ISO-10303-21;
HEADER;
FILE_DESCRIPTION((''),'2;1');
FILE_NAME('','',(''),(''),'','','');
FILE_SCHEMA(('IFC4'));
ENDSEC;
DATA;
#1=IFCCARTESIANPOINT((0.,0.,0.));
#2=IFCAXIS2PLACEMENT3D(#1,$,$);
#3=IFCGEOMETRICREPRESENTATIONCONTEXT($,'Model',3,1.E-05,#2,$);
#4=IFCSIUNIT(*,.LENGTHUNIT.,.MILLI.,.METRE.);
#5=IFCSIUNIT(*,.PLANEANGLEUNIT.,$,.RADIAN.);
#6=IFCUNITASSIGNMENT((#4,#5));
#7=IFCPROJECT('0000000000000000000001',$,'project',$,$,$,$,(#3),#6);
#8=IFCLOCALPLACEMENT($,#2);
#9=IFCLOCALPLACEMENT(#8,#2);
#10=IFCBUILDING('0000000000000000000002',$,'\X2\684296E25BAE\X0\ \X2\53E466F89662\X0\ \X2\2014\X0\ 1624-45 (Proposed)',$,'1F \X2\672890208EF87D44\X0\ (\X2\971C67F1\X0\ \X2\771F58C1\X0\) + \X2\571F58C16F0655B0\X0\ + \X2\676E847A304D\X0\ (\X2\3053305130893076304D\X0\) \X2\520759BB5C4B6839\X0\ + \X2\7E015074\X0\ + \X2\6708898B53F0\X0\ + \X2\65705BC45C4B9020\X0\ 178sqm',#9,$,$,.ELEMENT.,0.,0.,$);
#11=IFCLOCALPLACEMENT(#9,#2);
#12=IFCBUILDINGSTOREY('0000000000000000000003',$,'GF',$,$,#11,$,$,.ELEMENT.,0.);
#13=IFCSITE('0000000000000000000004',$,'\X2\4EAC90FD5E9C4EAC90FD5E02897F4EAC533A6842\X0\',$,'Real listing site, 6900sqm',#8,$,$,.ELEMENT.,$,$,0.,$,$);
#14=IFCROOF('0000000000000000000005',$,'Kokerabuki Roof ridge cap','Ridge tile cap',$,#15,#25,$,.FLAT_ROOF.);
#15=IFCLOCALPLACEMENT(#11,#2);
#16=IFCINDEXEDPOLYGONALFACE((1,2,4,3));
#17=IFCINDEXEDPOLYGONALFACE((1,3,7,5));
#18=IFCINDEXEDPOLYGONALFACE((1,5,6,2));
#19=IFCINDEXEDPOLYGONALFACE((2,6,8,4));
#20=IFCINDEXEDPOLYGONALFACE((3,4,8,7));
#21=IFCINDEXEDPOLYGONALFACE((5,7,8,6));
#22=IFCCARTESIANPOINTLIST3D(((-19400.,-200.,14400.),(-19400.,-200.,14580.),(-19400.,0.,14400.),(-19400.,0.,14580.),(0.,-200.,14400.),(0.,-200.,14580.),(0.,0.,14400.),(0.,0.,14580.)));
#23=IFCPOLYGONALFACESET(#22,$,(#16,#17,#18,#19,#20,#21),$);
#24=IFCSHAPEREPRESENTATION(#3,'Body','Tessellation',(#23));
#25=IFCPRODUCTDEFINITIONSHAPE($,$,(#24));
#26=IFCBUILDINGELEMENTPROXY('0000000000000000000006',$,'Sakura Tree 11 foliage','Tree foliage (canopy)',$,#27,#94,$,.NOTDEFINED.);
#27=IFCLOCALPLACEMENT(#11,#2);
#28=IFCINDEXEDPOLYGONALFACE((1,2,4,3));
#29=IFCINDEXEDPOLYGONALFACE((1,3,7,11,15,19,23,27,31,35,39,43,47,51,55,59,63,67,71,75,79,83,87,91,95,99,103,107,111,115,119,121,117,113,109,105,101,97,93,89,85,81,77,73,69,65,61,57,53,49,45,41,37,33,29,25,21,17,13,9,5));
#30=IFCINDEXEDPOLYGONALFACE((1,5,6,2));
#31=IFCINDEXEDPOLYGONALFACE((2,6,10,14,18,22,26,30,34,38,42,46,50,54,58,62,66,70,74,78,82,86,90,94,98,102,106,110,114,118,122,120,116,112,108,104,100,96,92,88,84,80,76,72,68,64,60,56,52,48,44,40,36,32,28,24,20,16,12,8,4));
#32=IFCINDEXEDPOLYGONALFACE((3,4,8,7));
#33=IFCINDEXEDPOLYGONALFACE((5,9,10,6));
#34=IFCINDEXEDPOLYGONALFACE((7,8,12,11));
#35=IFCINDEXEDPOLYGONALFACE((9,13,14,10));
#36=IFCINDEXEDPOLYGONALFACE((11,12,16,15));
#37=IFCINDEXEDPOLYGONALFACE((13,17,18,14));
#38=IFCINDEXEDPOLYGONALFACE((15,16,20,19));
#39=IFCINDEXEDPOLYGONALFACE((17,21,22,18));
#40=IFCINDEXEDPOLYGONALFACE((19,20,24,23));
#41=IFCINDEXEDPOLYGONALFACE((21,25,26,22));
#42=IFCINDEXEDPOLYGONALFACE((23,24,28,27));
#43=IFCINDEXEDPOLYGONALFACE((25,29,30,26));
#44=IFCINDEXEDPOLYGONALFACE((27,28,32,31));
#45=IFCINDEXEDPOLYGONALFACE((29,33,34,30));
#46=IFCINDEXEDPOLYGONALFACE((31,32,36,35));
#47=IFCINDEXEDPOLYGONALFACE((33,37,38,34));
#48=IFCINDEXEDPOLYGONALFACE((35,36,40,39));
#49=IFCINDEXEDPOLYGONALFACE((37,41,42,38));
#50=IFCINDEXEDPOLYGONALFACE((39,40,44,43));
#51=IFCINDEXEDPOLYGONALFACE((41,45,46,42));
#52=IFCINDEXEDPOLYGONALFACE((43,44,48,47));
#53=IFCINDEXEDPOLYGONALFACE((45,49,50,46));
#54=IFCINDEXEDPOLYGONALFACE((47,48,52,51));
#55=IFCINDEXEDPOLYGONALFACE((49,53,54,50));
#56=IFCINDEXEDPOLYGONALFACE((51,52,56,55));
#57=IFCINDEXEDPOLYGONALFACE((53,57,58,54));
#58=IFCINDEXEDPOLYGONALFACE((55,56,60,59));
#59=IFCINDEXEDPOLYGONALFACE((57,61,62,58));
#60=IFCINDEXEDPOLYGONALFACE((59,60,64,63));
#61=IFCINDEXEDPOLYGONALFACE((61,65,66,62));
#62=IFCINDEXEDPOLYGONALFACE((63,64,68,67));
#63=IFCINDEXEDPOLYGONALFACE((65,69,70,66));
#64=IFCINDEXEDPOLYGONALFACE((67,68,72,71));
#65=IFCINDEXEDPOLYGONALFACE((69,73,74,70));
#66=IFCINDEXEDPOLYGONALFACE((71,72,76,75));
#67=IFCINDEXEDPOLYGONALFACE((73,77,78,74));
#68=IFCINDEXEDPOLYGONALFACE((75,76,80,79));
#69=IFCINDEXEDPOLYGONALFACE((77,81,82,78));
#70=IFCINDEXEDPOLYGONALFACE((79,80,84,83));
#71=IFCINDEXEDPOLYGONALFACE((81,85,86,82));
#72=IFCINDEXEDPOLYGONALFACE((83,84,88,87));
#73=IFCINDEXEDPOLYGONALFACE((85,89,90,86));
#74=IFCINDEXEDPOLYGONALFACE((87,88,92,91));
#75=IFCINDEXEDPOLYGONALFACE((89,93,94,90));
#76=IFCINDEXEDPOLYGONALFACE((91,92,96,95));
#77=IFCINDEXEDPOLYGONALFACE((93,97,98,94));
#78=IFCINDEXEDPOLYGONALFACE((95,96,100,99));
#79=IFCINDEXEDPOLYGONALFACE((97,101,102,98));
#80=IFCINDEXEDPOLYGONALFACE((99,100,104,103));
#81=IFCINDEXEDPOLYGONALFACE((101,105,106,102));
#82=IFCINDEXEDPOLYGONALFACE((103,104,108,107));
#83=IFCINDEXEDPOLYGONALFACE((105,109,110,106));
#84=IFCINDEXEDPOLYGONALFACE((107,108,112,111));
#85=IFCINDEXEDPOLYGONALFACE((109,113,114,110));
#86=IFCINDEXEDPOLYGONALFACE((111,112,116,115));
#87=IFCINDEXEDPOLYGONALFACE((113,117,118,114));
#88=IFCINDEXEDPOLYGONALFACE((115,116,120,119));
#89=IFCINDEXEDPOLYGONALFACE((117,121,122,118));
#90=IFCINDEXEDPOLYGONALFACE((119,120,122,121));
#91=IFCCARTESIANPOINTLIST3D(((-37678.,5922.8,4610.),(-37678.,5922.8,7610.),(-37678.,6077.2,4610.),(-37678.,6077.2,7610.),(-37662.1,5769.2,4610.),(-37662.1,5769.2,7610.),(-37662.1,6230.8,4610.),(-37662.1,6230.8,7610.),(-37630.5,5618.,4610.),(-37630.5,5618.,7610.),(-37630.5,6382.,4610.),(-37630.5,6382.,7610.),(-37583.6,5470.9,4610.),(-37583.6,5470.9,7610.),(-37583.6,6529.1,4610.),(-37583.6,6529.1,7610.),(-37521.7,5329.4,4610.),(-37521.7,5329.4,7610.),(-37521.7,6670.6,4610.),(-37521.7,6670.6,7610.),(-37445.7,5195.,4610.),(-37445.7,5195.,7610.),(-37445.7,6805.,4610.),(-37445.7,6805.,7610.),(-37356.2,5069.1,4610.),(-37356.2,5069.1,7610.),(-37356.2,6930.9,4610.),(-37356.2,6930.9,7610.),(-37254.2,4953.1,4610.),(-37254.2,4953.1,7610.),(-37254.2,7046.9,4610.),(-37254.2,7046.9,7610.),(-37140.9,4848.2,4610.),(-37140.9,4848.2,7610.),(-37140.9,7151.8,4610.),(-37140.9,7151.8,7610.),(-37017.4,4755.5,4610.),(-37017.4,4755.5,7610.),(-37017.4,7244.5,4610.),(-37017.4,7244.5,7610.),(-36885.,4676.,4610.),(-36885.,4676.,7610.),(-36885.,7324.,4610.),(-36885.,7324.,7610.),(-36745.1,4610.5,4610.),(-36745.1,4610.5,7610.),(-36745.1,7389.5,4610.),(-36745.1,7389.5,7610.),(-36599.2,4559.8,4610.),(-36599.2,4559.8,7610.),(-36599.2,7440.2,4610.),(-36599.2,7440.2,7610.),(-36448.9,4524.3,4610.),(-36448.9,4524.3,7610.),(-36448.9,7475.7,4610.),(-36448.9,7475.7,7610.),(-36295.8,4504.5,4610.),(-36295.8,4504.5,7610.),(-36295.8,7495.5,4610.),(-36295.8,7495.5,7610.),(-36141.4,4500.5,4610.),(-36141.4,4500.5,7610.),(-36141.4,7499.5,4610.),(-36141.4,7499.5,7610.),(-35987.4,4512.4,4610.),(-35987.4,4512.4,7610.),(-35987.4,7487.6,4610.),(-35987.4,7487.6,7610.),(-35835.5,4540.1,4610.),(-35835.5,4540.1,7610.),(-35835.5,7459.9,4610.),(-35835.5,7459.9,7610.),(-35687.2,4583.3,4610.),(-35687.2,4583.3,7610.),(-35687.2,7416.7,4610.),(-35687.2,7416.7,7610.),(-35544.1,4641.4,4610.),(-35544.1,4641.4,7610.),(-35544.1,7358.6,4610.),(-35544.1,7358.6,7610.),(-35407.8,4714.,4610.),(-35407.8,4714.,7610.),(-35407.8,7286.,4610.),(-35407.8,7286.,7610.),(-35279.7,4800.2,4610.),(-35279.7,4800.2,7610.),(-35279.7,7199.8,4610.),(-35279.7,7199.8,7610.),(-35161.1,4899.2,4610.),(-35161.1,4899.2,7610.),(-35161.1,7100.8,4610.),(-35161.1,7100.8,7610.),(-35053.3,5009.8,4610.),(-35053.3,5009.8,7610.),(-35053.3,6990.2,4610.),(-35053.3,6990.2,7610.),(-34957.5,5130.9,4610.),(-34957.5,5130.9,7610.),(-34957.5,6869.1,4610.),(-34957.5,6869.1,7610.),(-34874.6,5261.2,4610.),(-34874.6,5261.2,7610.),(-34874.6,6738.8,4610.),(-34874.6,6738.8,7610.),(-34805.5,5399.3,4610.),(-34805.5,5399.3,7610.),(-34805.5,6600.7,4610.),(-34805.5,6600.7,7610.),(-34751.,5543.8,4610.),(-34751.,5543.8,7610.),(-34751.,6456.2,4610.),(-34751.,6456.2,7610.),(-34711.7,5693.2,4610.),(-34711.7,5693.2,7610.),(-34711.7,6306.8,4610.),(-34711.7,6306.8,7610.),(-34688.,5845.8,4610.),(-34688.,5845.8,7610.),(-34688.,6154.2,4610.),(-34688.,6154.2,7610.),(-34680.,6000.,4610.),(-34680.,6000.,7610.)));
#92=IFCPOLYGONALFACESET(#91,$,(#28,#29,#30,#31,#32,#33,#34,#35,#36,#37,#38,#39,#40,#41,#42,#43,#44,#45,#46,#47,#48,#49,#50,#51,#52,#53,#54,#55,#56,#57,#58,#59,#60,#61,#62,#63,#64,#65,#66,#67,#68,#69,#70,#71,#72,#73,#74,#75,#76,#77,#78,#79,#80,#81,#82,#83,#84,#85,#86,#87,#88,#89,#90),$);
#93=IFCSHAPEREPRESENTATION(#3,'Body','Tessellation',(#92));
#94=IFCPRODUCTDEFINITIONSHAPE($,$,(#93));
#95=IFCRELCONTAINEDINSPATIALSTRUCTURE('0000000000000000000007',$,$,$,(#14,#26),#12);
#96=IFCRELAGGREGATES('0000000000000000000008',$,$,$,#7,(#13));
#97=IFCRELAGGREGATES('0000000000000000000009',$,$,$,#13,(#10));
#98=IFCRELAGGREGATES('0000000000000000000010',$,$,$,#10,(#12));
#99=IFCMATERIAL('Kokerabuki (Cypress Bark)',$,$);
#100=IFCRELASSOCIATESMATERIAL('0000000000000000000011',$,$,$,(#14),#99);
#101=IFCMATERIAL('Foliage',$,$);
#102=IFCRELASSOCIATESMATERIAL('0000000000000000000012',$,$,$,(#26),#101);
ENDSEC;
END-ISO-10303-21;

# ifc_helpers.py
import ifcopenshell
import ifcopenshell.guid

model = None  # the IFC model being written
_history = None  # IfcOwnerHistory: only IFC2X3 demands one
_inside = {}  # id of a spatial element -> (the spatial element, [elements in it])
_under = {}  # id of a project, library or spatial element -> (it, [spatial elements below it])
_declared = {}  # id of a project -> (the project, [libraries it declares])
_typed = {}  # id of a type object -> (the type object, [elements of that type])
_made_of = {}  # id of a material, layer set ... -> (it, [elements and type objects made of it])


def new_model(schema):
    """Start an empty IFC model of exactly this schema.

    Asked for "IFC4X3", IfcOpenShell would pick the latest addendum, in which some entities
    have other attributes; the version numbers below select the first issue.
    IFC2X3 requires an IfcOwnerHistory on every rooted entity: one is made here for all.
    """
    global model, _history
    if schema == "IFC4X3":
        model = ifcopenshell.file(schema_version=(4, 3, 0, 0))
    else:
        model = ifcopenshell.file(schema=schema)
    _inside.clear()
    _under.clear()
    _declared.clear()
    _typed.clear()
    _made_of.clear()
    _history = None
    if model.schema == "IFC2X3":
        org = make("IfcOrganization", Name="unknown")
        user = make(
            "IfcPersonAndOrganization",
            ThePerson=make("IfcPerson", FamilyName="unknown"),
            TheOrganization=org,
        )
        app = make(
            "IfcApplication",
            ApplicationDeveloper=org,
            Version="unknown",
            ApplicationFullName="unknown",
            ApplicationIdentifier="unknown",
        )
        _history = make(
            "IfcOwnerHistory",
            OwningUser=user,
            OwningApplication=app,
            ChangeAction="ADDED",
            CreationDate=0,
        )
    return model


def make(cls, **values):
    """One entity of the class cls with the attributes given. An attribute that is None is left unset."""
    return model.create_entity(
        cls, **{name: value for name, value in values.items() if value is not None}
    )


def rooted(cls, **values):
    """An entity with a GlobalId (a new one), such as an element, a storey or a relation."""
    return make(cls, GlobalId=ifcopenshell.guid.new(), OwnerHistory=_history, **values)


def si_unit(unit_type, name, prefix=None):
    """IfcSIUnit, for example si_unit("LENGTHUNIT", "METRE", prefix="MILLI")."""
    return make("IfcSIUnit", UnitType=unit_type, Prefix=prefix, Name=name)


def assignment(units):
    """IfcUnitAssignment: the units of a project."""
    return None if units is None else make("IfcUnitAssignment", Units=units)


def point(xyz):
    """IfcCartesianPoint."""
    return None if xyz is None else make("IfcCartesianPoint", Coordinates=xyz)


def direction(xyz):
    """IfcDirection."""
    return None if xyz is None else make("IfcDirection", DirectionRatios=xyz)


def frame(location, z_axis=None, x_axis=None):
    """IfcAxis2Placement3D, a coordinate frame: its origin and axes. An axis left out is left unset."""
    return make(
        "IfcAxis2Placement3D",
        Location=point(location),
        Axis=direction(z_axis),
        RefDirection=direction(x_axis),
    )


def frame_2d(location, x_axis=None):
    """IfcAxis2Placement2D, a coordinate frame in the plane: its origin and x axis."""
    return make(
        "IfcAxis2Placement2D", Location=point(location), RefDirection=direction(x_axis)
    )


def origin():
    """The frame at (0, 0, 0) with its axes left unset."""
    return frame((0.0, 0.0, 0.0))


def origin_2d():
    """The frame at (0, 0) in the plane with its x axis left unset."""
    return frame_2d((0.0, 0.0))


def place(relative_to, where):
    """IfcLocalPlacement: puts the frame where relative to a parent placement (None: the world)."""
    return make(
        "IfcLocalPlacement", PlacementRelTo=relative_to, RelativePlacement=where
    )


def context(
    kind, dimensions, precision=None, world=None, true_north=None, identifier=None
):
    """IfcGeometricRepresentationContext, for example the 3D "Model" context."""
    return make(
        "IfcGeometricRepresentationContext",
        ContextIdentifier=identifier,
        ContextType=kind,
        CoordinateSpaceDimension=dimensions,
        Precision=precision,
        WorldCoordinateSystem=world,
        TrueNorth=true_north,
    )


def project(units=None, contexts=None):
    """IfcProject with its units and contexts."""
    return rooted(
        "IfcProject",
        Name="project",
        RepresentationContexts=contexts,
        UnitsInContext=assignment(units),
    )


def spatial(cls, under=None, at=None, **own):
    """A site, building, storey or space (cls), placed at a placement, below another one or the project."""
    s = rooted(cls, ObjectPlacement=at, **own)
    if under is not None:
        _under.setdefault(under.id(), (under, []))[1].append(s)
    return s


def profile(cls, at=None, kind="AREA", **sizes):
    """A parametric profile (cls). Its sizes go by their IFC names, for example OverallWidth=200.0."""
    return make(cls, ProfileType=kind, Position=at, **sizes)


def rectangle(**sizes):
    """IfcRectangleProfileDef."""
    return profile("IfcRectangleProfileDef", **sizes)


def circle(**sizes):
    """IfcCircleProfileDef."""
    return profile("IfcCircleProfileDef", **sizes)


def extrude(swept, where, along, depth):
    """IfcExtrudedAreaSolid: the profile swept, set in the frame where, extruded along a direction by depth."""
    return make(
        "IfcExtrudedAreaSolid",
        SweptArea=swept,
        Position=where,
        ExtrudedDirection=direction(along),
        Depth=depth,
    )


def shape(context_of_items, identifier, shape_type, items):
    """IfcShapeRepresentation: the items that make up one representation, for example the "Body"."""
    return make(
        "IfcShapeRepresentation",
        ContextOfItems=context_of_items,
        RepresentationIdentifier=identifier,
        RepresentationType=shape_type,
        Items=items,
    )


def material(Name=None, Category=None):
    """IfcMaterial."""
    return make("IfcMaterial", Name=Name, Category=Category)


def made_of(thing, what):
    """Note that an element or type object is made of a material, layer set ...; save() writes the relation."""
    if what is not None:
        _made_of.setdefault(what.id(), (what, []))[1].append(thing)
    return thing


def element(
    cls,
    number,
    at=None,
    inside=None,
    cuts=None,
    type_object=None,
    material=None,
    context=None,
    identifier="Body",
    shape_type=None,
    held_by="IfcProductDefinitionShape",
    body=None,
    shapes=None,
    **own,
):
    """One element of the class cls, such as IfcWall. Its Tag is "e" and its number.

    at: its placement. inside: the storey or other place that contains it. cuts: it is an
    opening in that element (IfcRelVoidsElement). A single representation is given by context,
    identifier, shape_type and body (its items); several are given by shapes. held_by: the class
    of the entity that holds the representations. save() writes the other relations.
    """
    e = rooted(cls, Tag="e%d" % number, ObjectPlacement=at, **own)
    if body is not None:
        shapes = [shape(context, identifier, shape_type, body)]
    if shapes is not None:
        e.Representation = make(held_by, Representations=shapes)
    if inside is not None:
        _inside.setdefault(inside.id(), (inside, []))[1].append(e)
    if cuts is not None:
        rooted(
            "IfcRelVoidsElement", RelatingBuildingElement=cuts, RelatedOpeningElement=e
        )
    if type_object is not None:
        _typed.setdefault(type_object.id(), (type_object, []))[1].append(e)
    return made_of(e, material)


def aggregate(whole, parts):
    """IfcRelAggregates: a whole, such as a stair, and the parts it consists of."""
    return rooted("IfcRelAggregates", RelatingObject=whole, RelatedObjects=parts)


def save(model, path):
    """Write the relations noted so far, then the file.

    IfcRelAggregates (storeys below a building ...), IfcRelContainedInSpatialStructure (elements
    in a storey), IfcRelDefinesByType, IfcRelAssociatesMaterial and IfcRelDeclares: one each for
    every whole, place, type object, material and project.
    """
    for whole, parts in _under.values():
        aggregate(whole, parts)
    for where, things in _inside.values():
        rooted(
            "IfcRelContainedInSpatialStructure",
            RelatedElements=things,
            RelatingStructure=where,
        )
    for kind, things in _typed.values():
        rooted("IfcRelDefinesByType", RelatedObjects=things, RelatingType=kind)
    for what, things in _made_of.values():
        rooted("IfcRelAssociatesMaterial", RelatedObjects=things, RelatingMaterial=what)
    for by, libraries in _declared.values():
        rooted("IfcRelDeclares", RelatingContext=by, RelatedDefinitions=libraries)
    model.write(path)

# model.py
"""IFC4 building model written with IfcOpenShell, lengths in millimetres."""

from ifc_helpers import new_model, si_unit, frame, frame_2d, origin, origin_2d, place, context, project, spatial, rectangle, circle, extrude, material, element, save


model = new_model("IFC4")

# Units and contexts
model_context = context("Model", 3, precision=1e-05, world=origin())
ifc_project = project(units=[si_unit("LENGTHUNIT", "METRE", prefix="MILLI"), si_unit("PLANEANGLEUNIT", "RADIAN")], contexts=[model_context])

# Site, building, storey
site_placement = place(None, origin())
site = spatial("IfcSite", under=ifc_project, at=site_placement, Name="京都府京都市西京区桂", ObjectType="Real listing site, 6900sqm", CompositionType="ELEMENT", RefElevation=0.0)
building_placement = place(site_placement, origin())
building = spatial("IfcBuilding", under=site, at=building_placement, Name="桂離宮 古書院 — 1624-45 (Proposed)", ObjectType="1F 木造軸組 (霜柱 真壁) + 土壁漆喰 + 杮葺き (こけらぶき) 切妻屋根 + 縁側 + 月見台 + 数寄屋造 178sqm", CompositionType="ELEMENT", ElevationOfRefHeight=0.0, ElevationOfTerrain=0.0)
storey_placement = place(building_placement, origin())
storey = spatial("IfcBuildingStorey", under=building, at=storey_placement, Name="GF", CompositionType="ELEMENT", Elevation=0.0)

# Roof
ifc_material_1 = material(Name="Kokerabuki (Cypress Bark)")
roof_1_placement = place(storey_placement, frame((-9700.0, -100.0, 7200.0)))
element("IfcRoof", 1, at=roof_1_placement, inside=storey, material=ifc_material_1, Name="Kokerabuki Roof ridge cap", Description="Ridge tile cap", PredefinedType="FLAT_ROOF", context=model_context, shape_type="SweptSolid", body=[
    extrude(rectangle(XDim=19400.0, YDim=200.0, at=frame_2d((9700.0, 100.0))), frame((-9700.0, -100.0, 7200.0)), (0.0, 0.0, 1.0), 180.0),
])

# Building element proxy
ifc_material_2 = material(Name="Foliage")
proxy_1_placement = place(storey_placement, frame((-18090.0, 3000.0, 2305.0)))
element("IfcBuildingElementProxy", 2, at=proxy_1_placement, inside=storey, material=ifc_material_2, Name="Sakura Tree 11 foliage", Description="Tree foliage (canopy)", PredefinedType="NOTDEFINED", context=model_context, shape_type="SweptSolid", body=[
    extrude(circle(Radius=1500.0, at=origin_2d()), frame((-18090.0, 3000.0, 2305.0)), (0.0, 0.0, 1.0), 3000.0),
])

save(model, "model.ifc")
